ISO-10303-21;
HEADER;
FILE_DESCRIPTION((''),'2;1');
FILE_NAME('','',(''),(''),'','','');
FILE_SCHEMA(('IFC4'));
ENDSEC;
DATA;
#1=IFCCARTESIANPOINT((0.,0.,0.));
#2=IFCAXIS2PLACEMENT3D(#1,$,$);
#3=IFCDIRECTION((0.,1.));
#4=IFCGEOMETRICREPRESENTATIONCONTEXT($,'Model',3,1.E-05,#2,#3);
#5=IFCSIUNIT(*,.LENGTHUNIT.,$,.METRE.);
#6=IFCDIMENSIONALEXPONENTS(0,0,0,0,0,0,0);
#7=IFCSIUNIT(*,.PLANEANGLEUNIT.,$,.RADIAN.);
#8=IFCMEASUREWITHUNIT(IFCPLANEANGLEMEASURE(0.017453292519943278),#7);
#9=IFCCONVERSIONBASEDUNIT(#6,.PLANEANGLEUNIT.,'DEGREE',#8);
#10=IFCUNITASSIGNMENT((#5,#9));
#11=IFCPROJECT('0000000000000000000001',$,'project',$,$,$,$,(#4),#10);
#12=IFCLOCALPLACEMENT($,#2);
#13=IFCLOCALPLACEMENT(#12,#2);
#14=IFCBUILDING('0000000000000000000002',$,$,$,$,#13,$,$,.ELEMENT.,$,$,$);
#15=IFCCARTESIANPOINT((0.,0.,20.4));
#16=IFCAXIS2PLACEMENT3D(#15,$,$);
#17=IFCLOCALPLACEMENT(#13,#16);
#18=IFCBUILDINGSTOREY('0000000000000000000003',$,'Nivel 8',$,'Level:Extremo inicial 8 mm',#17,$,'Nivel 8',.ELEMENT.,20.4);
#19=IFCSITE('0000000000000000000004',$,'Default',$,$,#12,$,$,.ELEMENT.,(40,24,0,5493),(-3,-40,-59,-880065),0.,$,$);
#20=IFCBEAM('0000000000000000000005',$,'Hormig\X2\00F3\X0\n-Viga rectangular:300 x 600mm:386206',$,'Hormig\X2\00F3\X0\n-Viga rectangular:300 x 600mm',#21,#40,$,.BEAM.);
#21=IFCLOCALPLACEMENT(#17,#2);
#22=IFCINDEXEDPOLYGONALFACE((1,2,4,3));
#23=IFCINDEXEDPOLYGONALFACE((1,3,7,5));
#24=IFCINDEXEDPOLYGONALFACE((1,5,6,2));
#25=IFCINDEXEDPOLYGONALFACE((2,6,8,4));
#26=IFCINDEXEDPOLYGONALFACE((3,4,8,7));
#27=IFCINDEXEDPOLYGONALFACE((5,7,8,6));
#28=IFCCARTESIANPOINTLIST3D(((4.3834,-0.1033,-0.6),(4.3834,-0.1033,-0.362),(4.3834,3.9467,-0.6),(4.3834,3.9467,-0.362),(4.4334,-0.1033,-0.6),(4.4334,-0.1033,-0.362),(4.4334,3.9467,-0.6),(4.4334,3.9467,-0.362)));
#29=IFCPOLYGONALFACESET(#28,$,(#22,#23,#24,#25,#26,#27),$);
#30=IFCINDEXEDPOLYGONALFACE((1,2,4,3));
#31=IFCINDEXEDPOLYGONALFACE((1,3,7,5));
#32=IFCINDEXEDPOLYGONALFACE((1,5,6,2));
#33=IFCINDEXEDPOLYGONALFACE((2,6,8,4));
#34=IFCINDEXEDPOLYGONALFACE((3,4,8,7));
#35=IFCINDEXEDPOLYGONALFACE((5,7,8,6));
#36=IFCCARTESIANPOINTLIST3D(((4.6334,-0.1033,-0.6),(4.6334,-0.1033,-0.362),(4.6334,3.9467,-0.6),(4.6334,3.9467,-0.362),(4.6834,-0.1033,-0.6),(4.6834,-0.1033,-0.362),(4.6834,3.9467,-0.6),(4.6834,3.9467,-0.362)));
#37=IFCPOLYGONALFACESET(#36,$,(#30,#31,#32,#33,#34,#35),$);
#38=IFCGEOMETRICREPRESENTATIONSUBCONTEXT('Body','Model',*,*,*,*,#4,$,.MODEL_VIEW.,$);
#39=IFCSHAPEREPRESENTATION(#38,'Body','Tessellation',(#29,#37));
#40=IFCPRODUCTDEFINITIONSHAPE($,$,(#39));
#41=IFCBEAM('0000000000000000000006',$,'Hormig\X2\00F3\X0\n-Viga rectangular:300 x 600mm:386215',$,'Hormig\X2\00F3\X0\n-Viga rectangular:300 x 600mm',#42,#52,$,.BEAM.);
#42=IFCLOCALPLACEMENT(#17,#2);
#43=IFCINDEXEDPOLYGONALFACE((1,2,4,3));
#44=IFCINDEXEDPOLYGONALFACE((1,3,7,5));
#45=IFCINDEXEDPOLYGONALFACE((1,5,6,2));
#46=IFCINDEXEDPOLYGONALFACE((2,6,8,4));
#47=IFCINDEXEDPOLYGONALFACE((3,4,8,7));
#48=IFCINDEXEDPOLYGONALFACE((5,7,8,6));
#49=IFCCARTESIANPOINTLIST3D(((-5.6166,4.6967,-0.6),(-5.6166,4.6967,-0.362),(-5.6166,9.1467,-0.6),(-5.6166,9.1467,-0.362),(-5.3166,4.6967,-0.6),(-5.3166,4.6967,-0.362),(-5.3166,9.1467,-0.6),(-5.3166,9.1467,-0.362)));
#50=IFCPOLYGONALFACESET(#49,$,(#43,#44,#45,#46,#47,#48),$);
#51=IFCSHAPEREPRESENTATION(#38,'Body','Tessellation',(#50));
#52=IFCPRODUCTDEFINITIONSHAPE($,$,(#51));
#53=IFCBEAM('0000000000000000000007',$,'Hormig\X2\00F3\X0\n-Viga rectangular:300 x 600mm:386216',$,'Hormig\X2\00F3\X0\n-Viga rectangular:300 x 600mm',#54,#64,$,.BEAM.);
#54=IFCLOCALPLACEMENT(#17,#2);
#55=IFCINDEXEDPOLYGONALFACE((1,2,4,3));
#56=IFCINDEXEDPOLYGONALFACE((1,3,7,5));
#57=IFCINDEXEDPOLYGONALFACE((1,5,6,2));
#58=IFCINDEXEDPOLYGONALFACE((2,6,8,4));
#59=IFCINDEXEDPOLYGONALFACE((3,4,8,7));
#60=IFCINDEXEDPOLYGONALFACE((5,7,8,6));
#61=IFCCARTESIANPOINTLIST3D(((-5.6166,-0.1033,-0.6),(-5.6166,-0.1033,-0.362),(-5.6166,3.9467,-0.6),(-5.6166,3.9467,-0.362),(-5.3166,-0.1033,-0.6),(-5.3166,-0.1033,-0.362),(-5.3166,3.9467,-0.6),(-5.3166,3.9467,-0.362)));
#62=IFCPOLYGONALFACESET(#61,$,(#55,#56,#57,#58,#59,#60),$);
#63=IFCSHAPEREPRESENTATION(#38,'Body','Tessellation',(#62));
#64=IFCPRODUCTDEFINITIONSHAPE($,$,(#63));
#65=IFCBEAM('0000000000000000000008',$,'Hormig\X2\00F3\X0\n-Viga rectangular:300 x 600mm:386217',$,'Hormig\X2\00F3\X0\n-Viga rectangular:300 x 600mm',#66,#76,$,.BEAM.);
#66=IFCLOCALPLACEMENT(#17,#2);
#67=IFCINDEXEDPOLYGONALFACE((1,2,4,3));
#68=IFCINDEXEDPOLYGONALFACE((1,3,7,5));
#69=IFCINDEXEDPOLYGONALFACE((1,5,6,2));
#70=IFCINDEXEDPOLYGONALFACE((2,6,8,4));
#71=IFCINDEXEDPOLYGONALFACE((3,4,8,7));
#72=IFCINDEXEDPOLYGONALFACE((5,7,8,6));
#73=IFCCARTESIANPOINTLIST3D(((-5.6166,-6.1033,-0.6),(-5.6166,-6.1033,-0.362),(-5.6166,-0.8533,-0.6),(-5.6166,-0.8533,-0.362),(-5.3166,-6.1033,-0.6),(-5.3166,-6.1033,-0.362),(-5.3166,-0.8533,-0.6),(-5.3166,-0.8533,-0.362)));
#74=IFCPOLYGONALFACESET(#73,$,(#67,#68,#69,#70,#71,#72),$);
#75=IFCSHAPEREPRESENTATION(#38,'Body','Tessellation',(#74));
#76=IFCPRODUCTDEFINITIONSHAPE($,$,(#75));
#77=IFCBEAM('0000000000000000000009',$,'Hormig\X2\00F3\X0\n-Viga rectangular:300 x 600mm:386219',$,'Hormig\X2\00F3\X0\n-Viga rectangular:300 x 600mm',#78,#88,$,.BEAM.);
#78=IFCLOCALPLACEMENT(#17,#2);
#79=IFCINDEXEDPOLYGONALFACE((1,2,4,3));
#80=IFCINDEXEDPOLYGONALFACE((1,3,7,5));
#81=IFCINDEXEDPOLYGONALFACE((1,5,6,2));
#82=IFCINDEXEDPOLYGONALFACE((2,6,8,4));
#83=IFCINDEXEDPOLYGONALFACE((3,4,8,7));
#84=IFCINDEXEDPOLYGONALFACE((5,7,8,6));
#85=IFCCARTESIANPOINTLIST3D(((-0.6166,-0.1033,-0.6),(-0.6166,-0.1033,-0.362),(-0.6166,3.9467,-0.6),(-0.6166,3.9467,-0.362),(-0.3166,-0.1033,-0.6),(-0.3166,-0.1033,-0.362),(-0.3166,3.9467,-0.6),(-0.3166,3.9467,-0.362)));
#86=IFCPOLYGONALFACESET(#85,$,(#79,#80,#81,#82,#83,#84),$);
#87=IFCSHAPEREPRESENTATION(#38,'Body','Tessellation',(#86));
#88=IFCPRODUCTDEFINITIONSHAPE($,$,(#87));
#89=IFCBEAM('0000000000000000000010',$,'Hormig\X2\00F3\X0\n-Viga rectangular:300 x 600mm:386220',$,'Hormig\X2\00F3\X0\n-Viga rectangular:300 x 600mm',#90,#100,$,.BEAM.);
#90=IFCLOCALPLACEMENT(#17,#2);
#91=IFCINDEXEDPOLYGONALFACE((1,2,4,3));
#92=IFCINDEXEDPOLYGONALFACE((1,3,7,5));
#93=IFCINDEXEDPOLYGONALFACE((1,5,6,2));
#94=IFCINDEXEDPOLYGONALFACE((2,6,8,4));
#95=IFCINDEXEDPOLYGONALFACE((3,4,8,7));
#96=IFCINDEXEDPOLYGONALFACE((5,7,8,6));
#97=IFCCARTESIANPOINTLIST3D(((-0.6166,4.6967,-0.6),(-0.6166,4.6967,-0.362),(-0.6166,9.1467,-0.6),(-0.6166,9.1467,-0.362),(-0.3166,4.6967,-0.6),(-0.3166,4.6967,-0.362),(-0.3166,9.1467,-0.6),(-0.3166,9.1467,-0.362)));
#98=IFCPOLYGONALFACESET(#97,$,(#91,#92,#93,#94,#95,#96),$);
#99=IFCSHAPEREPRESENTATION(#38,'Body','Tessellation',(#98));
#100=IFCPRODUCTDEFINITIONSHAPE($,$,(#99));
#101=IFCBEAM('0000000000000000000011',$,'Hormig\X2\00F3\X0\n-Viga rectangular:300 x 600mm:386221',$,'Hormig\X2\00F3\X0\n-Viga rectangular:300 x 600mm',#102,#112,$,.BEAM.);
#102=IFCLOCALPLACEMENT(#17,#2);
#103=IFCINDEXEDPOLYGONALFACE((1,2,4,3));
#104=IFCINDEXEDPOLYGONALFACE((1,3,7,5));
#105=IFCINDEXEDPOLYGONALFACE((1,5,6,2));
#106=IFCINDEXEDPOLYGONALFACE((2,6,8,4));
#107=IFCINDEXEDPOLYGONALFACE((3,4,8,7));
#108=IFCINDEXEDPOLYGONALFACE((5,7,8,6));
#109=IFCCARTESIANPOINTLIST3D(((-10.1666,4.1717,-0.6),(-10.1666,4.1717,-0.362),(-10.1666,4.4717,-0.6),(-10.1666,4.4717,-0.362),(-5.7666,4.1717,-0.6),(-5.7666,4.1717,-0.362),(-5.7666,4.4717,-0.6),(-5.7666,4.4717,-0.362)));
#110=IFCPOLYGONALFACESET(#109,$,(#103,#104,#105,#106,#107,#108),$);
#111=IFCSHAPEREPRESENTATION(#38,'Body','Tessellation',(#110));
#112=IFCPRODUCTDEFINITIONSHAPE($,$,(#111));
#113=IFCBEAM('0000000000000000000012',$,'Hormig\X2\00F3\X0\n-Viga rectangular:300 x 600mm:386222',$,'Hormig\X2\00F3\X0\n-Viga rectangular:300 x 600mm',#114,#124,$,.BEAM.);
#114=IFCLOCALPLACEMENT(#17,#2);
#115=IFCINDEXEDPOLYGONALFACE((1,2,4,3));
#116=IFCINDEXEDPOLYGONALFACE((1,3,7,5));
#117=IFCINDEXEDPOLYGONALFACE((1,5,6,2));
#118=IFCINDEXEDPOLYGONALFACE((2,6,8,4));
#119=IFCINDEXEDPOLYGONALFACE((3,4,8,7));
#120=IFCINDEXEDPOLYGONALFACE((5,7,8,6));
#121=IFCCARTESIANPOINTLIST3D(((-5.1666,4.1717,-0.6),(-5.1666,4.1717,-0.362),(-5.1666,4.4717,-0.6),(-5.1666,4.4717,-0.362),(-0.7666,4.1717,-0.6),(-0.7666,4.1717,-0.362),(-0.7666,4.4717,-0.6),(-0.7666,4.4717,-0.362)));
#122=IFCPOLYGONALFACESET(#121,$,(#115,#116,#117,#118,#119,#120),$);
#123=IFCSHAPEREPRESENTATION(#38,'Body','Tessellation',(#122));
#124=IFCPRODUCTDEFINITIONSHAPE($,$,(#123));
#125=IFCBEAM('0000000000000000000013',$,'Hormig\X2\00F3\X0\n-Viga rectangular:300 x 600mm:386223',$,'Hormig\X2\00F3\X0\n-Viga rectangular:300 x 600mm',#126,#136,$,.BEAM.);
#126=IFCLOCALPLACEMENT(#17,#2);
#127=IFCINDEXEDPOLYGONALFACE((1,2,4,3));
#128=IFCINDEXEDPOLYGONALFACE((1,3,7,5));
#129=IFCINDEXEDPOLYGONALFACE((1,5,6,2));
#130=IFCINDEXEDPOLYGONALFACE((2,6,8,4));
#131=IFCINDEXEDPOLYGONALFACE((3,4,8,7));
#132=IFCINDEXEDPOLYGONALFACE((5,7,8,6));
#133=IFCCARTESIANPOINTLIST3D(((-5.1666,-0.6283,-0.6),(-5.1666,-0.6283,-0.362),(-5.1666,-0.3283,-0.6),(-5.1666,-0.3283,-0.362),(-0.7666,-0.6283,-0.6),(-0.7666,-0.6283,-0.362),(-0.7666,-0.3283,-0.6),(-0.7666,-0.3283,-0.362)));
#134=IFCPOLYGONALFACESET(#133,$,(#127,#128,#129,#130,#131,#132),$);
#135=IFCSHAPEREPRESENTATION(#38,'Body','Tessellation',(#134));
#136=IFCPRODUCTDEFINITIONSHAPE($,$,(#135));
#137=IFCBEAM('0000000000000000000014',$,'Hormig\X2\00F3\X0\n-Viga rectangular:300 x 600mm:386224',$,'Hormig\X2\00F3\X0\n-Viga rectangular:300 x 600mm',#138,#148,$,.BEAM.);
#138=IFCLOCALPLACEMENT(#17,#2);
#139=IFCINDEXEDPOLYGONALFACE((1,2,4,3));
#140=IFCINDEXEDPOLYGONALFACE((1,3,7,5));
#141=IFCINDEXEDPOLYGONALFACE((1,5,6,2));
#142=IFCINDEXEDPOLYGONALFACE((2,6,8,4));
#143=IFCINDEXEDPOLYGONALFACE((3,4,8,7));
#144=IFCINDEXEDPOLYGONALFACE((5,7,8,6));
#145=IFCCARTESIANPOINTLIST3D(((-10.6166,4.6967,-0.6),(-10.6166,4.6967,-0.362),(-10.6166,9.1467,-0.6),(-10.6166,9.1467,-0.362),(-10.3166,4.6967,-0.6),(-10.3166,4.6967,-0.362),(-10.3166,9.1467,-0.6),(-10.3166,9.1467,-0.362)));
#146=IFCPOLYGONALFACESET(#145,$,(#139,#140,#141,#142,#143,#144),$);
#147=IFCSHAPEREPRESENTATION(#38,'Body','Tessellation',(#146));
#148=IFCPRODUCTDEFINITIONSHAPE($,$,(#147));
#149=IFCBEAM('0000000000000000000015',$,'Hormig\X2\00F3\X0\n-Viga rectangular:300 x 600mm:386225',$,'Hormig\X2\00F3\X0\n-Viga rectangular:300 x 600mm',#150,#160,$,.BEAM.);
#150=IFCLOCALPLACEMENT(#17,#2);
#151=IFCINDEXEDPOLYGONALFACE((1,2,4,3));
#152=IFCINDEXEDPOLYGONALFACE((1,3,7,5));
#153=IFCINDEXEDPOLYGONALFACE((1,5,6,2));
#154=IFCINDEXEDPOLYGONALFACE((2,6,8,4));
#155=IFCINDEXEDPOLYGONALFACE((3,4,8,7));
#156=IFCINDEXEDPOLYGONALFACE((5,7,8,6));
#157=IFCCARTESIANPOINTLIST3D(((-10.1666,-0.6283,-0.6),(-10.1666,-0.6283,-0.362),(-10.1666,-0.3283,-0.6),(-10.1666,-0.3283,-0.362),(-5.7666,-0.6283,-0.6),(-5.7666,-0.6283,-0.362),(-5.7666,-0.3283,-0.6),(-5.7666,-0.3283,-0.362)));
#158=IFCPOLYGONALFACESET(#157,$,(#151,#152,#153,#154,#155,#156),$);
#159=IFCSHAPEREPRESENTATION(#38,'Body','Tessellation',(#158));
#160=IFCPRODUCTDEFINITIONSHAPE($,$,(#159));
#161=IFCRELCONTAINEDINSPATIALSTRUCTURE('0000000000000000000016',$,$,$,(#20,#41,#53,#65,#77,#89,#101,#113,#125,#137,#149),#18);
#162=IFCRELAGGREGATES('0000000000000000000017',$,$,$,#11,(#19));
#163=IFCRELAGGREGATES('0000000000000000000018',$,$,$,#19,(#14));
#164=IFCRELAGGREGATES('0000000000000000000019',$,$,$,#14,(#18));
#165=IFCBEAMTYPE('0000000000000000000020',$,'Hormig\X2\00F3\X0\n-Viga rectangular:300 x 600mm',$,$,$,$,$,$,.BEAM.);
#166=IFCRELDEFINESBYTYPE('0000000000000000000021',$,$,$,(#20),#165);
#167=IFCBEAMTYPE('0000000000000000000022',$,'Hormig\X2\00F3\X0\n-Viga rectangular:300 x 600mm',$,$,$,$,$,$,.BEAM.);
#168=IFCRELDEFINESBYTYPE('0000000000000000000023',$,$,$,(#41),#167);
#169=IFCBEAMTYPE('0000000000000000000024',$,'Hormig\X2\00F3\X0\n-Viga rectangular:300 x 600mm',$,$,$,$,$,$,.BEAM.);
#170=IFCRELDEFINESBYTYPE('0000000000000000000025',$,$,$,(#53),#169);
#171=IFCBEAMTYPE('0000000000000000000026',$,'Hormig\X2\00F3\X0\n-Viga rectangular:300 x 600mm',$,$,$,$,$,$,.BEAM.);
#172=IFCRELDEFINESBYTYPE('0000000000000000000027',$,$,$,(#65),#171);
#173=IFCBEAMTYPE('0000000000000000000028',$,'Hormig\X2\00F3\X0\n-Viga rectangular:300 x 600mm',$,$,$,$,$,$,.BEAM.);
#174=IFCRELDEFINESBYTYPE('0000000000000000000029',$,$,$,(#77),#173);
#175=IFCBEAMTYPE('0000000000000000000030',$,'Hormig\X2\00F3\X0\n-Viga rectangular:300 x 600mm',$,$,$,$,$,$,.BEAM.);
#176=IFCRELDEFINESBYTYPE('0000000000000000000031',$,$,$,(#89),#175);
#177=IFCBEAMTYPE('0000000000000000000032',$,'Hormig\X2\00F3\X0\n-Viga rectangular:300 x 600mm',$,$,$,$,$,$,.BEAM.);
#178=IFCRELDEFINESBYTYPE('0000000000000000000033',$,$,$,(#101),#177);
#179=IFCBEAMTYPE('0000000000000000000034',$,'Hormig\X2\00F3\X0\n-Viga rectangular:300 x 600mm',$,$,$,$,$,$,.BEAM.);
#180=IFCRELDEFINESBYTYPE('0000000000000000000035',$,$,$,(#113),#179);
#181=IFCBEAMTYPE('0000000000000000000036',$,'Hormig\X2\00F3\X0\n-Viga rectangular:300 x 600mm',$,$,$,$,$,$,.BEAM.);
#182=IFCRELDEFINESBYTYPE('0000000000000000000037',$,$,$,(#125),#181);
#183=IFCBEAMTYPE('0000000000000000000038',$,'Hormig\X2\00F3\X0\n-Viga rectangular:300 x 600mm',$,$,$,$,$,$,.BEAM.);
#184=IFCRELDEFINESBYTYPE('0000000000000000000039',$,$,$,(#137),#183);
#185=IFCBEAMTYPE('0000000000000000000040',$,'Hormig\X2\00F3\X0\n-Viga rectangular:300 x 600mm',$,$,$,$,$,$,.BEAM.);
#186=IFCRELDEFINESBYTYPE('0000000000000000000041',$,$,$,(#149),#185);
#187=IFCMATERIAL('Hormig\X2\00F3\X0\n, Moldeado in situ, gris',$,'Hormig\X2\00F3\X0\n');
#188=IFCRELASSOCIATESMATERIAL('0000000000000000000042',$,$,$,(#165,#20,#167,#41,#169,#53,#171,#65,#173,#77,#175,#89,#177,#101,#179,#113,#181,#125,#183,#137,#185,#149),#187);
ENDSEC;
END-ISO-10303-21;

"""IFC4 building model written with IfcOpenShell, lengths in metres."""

from ifc_helpers import new_model, entity, si_unit, converted_unit, direction, frame, origin, place, context, subcontext, project, spatial, indexed_curve, outline, extrude, source, transform, mapped, material, type_object, type_shapes, element, save


model = new_model("IFC4")

# Units and contexts
model_context = context("Model", 3, precision=1e-05, world=origin(), true_north=direction((0.0, 1.0)))
body_context = subcontext(model_context, "Body", "Model", "MODEL_VIEW")
ifc_project = project(units=[si_unit("LENGTHUNIT", "METRE"), converted_unit("PLANEANGLEUNIT", "DEGREE", entity("IfcPlaneAngleMeasure", 0.017453292519943278), si_unit("PLANEANGLEUNIT", "RADIAN"), dimensions=[0, 0, 0, 0, 0, 0, 0])], contexts=[model_context])

# Site, building, storey
site_placement = place(None, origin())
site = spatial("IfcSite", under=ifc_project, at=site_placement, Name="Default", CompositionType="ELEMENT", RefLatitude=(40, 24, 0, 5493), RefLongitude=(-3, -40, -59, -880065), RefElevation=0.0)
building_placement = place(site_placement, origin())
building = spatial("IfcBuilding", under=site, at=building_placement, CompositionType="ELEMENT")
storey_placement = place(building_placement, frame((0.0, 0.0, 20.4)))
storey = spatial("IfcBuildingStorey", under=building, at=storey_placement, Name="Nivel 8", ObjectType="Level:Extremo inicial 8 mm", LongName="Nivel 8", CompositionType="ELEMENT", Elevation=20.4)

# Shared definitions
ifc_material_1 = material(Name="Hormigón, Moldeado in situ, gris", Category="Hormigón")

# Beams
beam_type_1 = type_object("IfcBeamType", Name="Hormigón-Viga rectangular:300 x 600mm", PredefinedType="BEAM", material=ifc_material_1)
shared_shape_1 = source(origin(), body_context, "Body", "SweptSolid", [
    extrude(outline(indexed_curve([(-0.025, -0.119), (0.025, -0.119), (0.025, 0.119), (-0.025, 0.119), (-0.025, -0.119)], self_intersect=False)), frame((4.4084, 3.9467, 19.919), z_axis=(0.0, -1.0, 0.0), x_axis=(-1.0, 0.0, 0.0)), (0.0, 0.0, 1.0), 4.05),
    extrude(outline(indexed_curve([(-0.025, -0.119), (0.025, -0.119), (0.025, 0.119), (-0.025, 0.119), (-0.025, -0.119)], self_intersect=False)), frame((4.6584, 3.9467, 19.919), z_axis=(0.0, -1.0, 0.0), x_axis=(-1.0, 0.0, 0.0)), (0.0, 0.0, 1.0), 4.05),
])
type_shapes(beam_type_1, [shared_shape_1])
beam_1_placement = place(storey_placement, frame((0.0, 0.0, -20.4)))
element("IfcBeam", 1, at=beam_1_placement, inside=storey, type_object=beam_type_1, material=ifc_material_1, Name="Hormigón-Viga rectangular:300 x 600mm:386206", ObjectType="Hormigón-Viga rectangular:300 x 600mm", PredefinedType="BEAM", context=body_context, shape_type="MappedRepresentation", body=[
    mapped(shared_shape_1, transform((0.0, 0.0, 0.0), scale=1.0)),
])
beam_type_2 = type_object("IfcBeamType", Name="Hormigón-Viga rectangular:300 x 600mm", PredefinedType="BEAM", material=ifc_material_1)
shared_shape_2 = source(origin(), body_context, "Body", "SweptSolid", [
    extrude(outline(indexed_curve([(-0.15, -0.119), (0.15, -0.119), (0.15, 0.119), (-0.15, 0.119), (-0.15, -0.119)], self_intersect=False)), frame((-5.4666, 9.1467, 19.919), z_axis=(0.0, -1.0, 0.0), x_axis=(-1.0, 0.0, 0.0)), (0.0, 0.0, 1.0), 4.45),
])
type_shapes(beam_type_2, [shared_shape_2])
beam_2_placement = place(storey_placement, frame((0.0, 0.0, -20.4)))
element("IfcBeam", 2, at=beam_2_placement, inside=storey, type_object=beam_type_2, material=ifc_material_1, Name="Hormigón-Viga rectangular:300 x 600mm:386215", ObjectType="Hormigón-Viga rectangular:300 x 600mm", PredefinedType="BEAM", context=body_context, shape_type="MappedRepresentation", body=[
    mapped(shared_shape_2, transform((0.0, 0.0, 0.0), scale=1.0)),
])
beam_type_3 = type_object("IfcBeamType", Name="Hormigón-Viga rectangular:300 x 600mm", PredefinedType="BEAM", material=ifc_material_1)
shared_shape_3 = source(origin(), body_context, "Body", "SweptSolid", [
    extrude(outline(indexed_curve([(-0.15, -0.119), (0.15, -0.119), (0.15, 0.119), (-0.15, 0.119), (-0.15, -0.119)], self_intersect=False)), frame((-5.4666, 3.9467, 19.919), z_axis=(0.0, -1.0, 0.0), x_axis=(-1.0, 0.0, 0.0)), (0.0, 0.0, 1.0), 4.05),
])
type_shapes(beam_type_3, [shared_shape_3])
beam_3_placement = place(storey_placement, frame((0.0, 0.0, -20.4)))
element("IfcBeam", 3, at=beam_3_placement, inside=storey, type_object=beam_type_3, material=ifc_material_1, Name="Hormigón-Viga rectangular:300 x 600mm:386216", ObjectType="Hormigón-Viga rectangular:300 x 600mm", PredefinedType="BEAM", context=body_context, shape_type="MappedRepresentation", body=[
    mapped(shared_shape_3, transform((0.0, 0.0, 0.0), scale=1.0)),
])
beam_type_4 = type_object("IfcBeamType", Name="Hormigón-Viga rectangular:300 x 600mm", PredefinedType="BEAM", material=ifc_material_1)
shared_shape_4 = source(origin(), body_context, "Body", "SweptSolid", [
    extrude(outline(indexed_curve([(-0.15, -0.119), (0.15, -0.119), (0.15, 0.119), (-0.15, 0.119), (-0.15, -0.119)], self_intersect=False)), frame((-5.4666, -6.1033, 19.919), z_axis=(0.0, 1.0, 0.0), x_axis=(-1.0, 0.0, 0.0)), (0.0, 0.0, 1.0), 5.25),
])
type_shapes(beam_type_4, [shared_shape_4])
beam_4_placement = place(storey_placement, frame((0.0, 0.0, -20.4)))
element("IfcBeam", 4, at=beam_4_placement, inside=storey, type_object=beam_type_4, material=ifc_material_1, Name="Hormigón-Viga rectangular:300 x 600mm:386217", ObjectType="Hormigón-Viga rectangular:300 x 600mm", PredefinedType="BEAM", context=body_context, shape_type="MappedRepresentation", body=[
    mapped(shared_shape_4, transform((0.0, 0.0, 0.0), scale=1.0)),
])
beam_type_5 = type_object("IfcBeamType", Name="Hormigón-Viga rectangular:300 x 600mm", PredefinedType="BEAM", material=ifc_material_1)
shared_shape_5 = source(origin(), body_context, "Body", "SweptSolid", [
    extrude(outline(indexed_curve([(-0.15, -0.119), (0.15, -0.119), (0.15, 0.119), (-0.15, 0.119), (-0.15, -0.119)], self_intersect=False)), frame((-0.4666, -0.1033, 19.919), z_axis=(0.0, 1.0, 0.0), x_axis=(-1.0, 0.0, 0.0)), (0.0, 0.0, 1.0), 4.05),
])
type_shapes(beam_type_5, [shared_shape_5])
beam_5_placement = place(storey_placement, frame((0.0, 0.0, -20.4)))
element("IfcBeam", 5, at=beam_5_placement, inside=storey, type_object=beam_type_5, material=ifc_material_1, Name="Hormigón-Viga rectangular:300 x 600mm:386219", ObjectType="Hormigón-Viga rectangular:300 x 600mm", PredefinedType="BEAM", context=body_context, shape_type="MappedRepresentation", body=[
    mapped(shared_shape_5, transform((0.0, 0.0, 0.0), scale=1.0)),
])
beam_type_6 = type_object("IfcBeamType", Name="Hormigón-Viga rectangular:300 x 600mm", PredefinedType="BEAM", material=ifc_material_1)
shared_shape_6 = source(origin(), body_context, "Body", "SweptSolid", [
    extrude(outline(indexed_curve([(-0.15, -0.119), (0.15, -0.119), (0.15, 0.119), (-0.15, 0.119), (-0.15, -0.119)], self_intersect=False)), frame((-0.4666, 9.1467, 19.919), z_axis=(0.0, -1.0, 0.0), x_axis=(-1.0, 0.0, 0.0)), (0.0, 0.0, 1.0), 4.45),
])
type_shapes(beam_type_6, [shared_shape_6])
beam_6_placement = place(storey_placement, frame((0.0, 0.0, -20.4)))
element("IfcBeam", 6, at=beam_6_placement, inside=storey, type_object=beam_type_6, material=ifc_material_1, Name="Hormigón-Viga rectangular:300 x 600mm:386220", ObjectType="Hormigón-Viga rectangular:300 x 600mm", PredefinedType="BEAM", context=body_context, shape_type="MappedRepresentation", body=[
    mapped(shared_shape_6, transform((0.0, 0.0, 0.0), scale=1.0)),
])
beam_type_7 = type_object("IfcBeamType", Name="Hormigón-Viga rectangular:300 x 600mm", PredefinedType="BEAM", material=ifc_material_1)
shared_shape_7 = source(origin(), body_context, "Body", "SweptSolid", [
    extrude(outline(indexed_curve([(-0.119, -0.15), (0.119, -0.15), (0.119, 0.15), (-0.119, 0.15), (-0.119, -0.15)], self_intersect=False)), frame((-10.1666, 4.3217, 19.919), z_axis=(1.0, 0.0, 0.0), x_axis=(0.0, 0.0, -1.0)), (0.0, 0.0, 1.0), 4.4),
])
type_shapes(beam_type_7, [shared_shape_7])
beam_7_placement = place(storey_placement, frame((0.0, 0.0, -20.4)))
element("IfcBeam", 7, at=beam_7_placement, inside=storey, type_object=beam_type_7, material=ifc_material_1, Name="Hormigón-Viga rectangular:300 x 600mm:386221", ObjectType="Hormigón-Viga rectangular:300 x 600mm", PredefinedType="BEAM", context=body_context, shape_type="MappedRepresentation", body=[
    mapped(shared_shape_7, transform((0.0, 0.0, 0.0), scale=1.0)),
])
beam_type_8 = type_object("IfcBeamType", Name="Hormigón-Viga rectangular:300 x 600mm", PredefinedType="BEAM", material=ifc_material_1)
shared_shape_8 = source(origin(), body_context, "Body", "SweptSolid", [
    extrude(outline(indexed_curve([(-0.119, -0.15), (0.119, -0.15), (0.119, 0.15), (-0.119, 0.15), (-0.119, -0.15)], self_intersect=False)), frame((-5.1666, 4.3217, 19.919), z_axis=(1.0, 0.0, 0.0), x_axis=(0.0, 0.0, -1.0)), (0.0, 0.0, 1.0), 4.4),
])
type_shapes(beam_type_8, [shared_shape_8])
beam_8_placement = place(storey_placement, frame((0.0, 0.0, -20.4)))
element("IfcBeam", 8, at=beam_8_placement, inside=storey, type_object=beam_type_8, material=ifc_material_1, Name="Hormigón-Viga rectangular:300 x 600mm:386222", ObjectType="Hormigón-Viga rectangular:300 x 600mm", PredefinedType="BEAM", context=body_context, shape_type="MappedRepresentation", body=[
    mapped(shared_shape_8, transform((0.0, 0.0, 0.0), scale=1.0)),
])
beam_type_9 = type_object("IfcBeamType", Name="Hormigón-Viga rectangular:300 x 600mm", PredefinedType="BEAM", material=ifc_material_1)
shared_shape_9 = source(origin(), body_context, "Body", "SweptSolid", [
    extrude(outline(indexed_curve([(-0.119, -0.15), (0.119, -0.15), (0.119, 0.15), (-0.119, 0.15), (-0.119, -0.15)], self_intersect=False)), frame((-0.7666, -0.4783, 19.919), z_axis=(-1.0, 0.0, 0.0), x_axis=(0.0, 0.0, -1.0)), (0.0, 0.0, 1.0), 4.4),
])
type_shapes(beam_type_9, [shared_shape_9])
beam_9_placement = place(storey_placement, frame((0.0, 0.0, -20.4)))
element("IfcBeam", 9, at=beam_9_placement, inside=storey, type_object=beam_type_9, material=ifc_material_1, Name="Hormigón-Viga rectangular:300 x 600mm:386223", ObjectType="Hormigón-Viga rectangular:300 x 600mm", PredefinedType="BEAM", context=body_context, shape_type="MappedRepresentation", body=[
    mapped(shared_shape_9, transform((0.0, 0.0, 0.0), scale=1.0)),
])
beam_type_10 = type_object("IfcBeamType", Name="Hormigón-Viga rectangular:300 x 600mm", PredefinedType="BEAM", material=ifc_material_1)
shared_shape_10 = source(origin(), body_context, "Body", "SweptSolid", [
    extrude(outline(indexed_curve([(-0.15, -0.119), (0.15, -0.119), (0.15, 0.119), (-0.15, 0.119), (-0.15, -0.119)], self_intersect=False)), frame((-10.4666, 4.6967, 19.919), z_axis=(0.0, 1.0, 0.0), x_axis=(-1.0, 0.0, 0.0)), (0.0, 0.0, 1.0), 4.45),
])
type_shapes(beam_type_10, [shared_shape_10])
beam_10_placement = place(storey_placement, frame((0.0, 0.0, -20.4)))
element("IfcBeam", 10, at=beam_10_placement, inside=storey, type_object=beam_type_10, material=ifc_material_1, Name="Hormigón-Viga rectangular:300 x 600mm:386224", ObjectType="Hormigón-Viga rectangular:300 x 600mm", PredefinedType="BEAM", context=body_context, shape_type="MappedRepresentation", body=[
    mapped(shared_shape_10, transform((0.0, 0.0, 0.0), scale=1.0)),
])
beam_type_11 = type_object("IfcBeamType", Name="Hormigón-Viga rectangular:300 x 600mm", PredefinedType="BEAM", material=ifc_material_1)
shared_shape_11 = source(origin(), body_context, "Body", "SweptSolid", [
    extrude(outline(indexed_curve([(-0.119, -0.15), (0.119, -0.15), (0.119, 0.15), (-0.119, 0.15), (-0.119, -0.15)], self_intersect=False)), frame((-10.1666, -0.4783, 19.919), z_axis=(1.0, 0.0, 0.0), x_axis=(0.0, 0.0, -1.0)), (0.0, 0.0, 1.0), 4.4),
])
type_shapes(beam_type_11, [shared_shape_11])
beam_11_placement = place(storey_placement, frame((0.0, 0.0, -20.4)))
element("IfcBeam", 11, at=beam_11_placement, inside=storey, type_object=beam_type_11, material=ifc_material_1, Name="Hormigón-Viga rectangular:300 x 600mm:386225", ObjectType="Hormigón-Viga rectangular:300 x 600mm", PredefinedType="BEAM", context=body_context, shape_type="MappedRepresentation", body=[
    mapped(shared_shape_11, transform((0.0, 0.0, 0.0), scale=1.0)),
])

save(model, "model.ifc")
